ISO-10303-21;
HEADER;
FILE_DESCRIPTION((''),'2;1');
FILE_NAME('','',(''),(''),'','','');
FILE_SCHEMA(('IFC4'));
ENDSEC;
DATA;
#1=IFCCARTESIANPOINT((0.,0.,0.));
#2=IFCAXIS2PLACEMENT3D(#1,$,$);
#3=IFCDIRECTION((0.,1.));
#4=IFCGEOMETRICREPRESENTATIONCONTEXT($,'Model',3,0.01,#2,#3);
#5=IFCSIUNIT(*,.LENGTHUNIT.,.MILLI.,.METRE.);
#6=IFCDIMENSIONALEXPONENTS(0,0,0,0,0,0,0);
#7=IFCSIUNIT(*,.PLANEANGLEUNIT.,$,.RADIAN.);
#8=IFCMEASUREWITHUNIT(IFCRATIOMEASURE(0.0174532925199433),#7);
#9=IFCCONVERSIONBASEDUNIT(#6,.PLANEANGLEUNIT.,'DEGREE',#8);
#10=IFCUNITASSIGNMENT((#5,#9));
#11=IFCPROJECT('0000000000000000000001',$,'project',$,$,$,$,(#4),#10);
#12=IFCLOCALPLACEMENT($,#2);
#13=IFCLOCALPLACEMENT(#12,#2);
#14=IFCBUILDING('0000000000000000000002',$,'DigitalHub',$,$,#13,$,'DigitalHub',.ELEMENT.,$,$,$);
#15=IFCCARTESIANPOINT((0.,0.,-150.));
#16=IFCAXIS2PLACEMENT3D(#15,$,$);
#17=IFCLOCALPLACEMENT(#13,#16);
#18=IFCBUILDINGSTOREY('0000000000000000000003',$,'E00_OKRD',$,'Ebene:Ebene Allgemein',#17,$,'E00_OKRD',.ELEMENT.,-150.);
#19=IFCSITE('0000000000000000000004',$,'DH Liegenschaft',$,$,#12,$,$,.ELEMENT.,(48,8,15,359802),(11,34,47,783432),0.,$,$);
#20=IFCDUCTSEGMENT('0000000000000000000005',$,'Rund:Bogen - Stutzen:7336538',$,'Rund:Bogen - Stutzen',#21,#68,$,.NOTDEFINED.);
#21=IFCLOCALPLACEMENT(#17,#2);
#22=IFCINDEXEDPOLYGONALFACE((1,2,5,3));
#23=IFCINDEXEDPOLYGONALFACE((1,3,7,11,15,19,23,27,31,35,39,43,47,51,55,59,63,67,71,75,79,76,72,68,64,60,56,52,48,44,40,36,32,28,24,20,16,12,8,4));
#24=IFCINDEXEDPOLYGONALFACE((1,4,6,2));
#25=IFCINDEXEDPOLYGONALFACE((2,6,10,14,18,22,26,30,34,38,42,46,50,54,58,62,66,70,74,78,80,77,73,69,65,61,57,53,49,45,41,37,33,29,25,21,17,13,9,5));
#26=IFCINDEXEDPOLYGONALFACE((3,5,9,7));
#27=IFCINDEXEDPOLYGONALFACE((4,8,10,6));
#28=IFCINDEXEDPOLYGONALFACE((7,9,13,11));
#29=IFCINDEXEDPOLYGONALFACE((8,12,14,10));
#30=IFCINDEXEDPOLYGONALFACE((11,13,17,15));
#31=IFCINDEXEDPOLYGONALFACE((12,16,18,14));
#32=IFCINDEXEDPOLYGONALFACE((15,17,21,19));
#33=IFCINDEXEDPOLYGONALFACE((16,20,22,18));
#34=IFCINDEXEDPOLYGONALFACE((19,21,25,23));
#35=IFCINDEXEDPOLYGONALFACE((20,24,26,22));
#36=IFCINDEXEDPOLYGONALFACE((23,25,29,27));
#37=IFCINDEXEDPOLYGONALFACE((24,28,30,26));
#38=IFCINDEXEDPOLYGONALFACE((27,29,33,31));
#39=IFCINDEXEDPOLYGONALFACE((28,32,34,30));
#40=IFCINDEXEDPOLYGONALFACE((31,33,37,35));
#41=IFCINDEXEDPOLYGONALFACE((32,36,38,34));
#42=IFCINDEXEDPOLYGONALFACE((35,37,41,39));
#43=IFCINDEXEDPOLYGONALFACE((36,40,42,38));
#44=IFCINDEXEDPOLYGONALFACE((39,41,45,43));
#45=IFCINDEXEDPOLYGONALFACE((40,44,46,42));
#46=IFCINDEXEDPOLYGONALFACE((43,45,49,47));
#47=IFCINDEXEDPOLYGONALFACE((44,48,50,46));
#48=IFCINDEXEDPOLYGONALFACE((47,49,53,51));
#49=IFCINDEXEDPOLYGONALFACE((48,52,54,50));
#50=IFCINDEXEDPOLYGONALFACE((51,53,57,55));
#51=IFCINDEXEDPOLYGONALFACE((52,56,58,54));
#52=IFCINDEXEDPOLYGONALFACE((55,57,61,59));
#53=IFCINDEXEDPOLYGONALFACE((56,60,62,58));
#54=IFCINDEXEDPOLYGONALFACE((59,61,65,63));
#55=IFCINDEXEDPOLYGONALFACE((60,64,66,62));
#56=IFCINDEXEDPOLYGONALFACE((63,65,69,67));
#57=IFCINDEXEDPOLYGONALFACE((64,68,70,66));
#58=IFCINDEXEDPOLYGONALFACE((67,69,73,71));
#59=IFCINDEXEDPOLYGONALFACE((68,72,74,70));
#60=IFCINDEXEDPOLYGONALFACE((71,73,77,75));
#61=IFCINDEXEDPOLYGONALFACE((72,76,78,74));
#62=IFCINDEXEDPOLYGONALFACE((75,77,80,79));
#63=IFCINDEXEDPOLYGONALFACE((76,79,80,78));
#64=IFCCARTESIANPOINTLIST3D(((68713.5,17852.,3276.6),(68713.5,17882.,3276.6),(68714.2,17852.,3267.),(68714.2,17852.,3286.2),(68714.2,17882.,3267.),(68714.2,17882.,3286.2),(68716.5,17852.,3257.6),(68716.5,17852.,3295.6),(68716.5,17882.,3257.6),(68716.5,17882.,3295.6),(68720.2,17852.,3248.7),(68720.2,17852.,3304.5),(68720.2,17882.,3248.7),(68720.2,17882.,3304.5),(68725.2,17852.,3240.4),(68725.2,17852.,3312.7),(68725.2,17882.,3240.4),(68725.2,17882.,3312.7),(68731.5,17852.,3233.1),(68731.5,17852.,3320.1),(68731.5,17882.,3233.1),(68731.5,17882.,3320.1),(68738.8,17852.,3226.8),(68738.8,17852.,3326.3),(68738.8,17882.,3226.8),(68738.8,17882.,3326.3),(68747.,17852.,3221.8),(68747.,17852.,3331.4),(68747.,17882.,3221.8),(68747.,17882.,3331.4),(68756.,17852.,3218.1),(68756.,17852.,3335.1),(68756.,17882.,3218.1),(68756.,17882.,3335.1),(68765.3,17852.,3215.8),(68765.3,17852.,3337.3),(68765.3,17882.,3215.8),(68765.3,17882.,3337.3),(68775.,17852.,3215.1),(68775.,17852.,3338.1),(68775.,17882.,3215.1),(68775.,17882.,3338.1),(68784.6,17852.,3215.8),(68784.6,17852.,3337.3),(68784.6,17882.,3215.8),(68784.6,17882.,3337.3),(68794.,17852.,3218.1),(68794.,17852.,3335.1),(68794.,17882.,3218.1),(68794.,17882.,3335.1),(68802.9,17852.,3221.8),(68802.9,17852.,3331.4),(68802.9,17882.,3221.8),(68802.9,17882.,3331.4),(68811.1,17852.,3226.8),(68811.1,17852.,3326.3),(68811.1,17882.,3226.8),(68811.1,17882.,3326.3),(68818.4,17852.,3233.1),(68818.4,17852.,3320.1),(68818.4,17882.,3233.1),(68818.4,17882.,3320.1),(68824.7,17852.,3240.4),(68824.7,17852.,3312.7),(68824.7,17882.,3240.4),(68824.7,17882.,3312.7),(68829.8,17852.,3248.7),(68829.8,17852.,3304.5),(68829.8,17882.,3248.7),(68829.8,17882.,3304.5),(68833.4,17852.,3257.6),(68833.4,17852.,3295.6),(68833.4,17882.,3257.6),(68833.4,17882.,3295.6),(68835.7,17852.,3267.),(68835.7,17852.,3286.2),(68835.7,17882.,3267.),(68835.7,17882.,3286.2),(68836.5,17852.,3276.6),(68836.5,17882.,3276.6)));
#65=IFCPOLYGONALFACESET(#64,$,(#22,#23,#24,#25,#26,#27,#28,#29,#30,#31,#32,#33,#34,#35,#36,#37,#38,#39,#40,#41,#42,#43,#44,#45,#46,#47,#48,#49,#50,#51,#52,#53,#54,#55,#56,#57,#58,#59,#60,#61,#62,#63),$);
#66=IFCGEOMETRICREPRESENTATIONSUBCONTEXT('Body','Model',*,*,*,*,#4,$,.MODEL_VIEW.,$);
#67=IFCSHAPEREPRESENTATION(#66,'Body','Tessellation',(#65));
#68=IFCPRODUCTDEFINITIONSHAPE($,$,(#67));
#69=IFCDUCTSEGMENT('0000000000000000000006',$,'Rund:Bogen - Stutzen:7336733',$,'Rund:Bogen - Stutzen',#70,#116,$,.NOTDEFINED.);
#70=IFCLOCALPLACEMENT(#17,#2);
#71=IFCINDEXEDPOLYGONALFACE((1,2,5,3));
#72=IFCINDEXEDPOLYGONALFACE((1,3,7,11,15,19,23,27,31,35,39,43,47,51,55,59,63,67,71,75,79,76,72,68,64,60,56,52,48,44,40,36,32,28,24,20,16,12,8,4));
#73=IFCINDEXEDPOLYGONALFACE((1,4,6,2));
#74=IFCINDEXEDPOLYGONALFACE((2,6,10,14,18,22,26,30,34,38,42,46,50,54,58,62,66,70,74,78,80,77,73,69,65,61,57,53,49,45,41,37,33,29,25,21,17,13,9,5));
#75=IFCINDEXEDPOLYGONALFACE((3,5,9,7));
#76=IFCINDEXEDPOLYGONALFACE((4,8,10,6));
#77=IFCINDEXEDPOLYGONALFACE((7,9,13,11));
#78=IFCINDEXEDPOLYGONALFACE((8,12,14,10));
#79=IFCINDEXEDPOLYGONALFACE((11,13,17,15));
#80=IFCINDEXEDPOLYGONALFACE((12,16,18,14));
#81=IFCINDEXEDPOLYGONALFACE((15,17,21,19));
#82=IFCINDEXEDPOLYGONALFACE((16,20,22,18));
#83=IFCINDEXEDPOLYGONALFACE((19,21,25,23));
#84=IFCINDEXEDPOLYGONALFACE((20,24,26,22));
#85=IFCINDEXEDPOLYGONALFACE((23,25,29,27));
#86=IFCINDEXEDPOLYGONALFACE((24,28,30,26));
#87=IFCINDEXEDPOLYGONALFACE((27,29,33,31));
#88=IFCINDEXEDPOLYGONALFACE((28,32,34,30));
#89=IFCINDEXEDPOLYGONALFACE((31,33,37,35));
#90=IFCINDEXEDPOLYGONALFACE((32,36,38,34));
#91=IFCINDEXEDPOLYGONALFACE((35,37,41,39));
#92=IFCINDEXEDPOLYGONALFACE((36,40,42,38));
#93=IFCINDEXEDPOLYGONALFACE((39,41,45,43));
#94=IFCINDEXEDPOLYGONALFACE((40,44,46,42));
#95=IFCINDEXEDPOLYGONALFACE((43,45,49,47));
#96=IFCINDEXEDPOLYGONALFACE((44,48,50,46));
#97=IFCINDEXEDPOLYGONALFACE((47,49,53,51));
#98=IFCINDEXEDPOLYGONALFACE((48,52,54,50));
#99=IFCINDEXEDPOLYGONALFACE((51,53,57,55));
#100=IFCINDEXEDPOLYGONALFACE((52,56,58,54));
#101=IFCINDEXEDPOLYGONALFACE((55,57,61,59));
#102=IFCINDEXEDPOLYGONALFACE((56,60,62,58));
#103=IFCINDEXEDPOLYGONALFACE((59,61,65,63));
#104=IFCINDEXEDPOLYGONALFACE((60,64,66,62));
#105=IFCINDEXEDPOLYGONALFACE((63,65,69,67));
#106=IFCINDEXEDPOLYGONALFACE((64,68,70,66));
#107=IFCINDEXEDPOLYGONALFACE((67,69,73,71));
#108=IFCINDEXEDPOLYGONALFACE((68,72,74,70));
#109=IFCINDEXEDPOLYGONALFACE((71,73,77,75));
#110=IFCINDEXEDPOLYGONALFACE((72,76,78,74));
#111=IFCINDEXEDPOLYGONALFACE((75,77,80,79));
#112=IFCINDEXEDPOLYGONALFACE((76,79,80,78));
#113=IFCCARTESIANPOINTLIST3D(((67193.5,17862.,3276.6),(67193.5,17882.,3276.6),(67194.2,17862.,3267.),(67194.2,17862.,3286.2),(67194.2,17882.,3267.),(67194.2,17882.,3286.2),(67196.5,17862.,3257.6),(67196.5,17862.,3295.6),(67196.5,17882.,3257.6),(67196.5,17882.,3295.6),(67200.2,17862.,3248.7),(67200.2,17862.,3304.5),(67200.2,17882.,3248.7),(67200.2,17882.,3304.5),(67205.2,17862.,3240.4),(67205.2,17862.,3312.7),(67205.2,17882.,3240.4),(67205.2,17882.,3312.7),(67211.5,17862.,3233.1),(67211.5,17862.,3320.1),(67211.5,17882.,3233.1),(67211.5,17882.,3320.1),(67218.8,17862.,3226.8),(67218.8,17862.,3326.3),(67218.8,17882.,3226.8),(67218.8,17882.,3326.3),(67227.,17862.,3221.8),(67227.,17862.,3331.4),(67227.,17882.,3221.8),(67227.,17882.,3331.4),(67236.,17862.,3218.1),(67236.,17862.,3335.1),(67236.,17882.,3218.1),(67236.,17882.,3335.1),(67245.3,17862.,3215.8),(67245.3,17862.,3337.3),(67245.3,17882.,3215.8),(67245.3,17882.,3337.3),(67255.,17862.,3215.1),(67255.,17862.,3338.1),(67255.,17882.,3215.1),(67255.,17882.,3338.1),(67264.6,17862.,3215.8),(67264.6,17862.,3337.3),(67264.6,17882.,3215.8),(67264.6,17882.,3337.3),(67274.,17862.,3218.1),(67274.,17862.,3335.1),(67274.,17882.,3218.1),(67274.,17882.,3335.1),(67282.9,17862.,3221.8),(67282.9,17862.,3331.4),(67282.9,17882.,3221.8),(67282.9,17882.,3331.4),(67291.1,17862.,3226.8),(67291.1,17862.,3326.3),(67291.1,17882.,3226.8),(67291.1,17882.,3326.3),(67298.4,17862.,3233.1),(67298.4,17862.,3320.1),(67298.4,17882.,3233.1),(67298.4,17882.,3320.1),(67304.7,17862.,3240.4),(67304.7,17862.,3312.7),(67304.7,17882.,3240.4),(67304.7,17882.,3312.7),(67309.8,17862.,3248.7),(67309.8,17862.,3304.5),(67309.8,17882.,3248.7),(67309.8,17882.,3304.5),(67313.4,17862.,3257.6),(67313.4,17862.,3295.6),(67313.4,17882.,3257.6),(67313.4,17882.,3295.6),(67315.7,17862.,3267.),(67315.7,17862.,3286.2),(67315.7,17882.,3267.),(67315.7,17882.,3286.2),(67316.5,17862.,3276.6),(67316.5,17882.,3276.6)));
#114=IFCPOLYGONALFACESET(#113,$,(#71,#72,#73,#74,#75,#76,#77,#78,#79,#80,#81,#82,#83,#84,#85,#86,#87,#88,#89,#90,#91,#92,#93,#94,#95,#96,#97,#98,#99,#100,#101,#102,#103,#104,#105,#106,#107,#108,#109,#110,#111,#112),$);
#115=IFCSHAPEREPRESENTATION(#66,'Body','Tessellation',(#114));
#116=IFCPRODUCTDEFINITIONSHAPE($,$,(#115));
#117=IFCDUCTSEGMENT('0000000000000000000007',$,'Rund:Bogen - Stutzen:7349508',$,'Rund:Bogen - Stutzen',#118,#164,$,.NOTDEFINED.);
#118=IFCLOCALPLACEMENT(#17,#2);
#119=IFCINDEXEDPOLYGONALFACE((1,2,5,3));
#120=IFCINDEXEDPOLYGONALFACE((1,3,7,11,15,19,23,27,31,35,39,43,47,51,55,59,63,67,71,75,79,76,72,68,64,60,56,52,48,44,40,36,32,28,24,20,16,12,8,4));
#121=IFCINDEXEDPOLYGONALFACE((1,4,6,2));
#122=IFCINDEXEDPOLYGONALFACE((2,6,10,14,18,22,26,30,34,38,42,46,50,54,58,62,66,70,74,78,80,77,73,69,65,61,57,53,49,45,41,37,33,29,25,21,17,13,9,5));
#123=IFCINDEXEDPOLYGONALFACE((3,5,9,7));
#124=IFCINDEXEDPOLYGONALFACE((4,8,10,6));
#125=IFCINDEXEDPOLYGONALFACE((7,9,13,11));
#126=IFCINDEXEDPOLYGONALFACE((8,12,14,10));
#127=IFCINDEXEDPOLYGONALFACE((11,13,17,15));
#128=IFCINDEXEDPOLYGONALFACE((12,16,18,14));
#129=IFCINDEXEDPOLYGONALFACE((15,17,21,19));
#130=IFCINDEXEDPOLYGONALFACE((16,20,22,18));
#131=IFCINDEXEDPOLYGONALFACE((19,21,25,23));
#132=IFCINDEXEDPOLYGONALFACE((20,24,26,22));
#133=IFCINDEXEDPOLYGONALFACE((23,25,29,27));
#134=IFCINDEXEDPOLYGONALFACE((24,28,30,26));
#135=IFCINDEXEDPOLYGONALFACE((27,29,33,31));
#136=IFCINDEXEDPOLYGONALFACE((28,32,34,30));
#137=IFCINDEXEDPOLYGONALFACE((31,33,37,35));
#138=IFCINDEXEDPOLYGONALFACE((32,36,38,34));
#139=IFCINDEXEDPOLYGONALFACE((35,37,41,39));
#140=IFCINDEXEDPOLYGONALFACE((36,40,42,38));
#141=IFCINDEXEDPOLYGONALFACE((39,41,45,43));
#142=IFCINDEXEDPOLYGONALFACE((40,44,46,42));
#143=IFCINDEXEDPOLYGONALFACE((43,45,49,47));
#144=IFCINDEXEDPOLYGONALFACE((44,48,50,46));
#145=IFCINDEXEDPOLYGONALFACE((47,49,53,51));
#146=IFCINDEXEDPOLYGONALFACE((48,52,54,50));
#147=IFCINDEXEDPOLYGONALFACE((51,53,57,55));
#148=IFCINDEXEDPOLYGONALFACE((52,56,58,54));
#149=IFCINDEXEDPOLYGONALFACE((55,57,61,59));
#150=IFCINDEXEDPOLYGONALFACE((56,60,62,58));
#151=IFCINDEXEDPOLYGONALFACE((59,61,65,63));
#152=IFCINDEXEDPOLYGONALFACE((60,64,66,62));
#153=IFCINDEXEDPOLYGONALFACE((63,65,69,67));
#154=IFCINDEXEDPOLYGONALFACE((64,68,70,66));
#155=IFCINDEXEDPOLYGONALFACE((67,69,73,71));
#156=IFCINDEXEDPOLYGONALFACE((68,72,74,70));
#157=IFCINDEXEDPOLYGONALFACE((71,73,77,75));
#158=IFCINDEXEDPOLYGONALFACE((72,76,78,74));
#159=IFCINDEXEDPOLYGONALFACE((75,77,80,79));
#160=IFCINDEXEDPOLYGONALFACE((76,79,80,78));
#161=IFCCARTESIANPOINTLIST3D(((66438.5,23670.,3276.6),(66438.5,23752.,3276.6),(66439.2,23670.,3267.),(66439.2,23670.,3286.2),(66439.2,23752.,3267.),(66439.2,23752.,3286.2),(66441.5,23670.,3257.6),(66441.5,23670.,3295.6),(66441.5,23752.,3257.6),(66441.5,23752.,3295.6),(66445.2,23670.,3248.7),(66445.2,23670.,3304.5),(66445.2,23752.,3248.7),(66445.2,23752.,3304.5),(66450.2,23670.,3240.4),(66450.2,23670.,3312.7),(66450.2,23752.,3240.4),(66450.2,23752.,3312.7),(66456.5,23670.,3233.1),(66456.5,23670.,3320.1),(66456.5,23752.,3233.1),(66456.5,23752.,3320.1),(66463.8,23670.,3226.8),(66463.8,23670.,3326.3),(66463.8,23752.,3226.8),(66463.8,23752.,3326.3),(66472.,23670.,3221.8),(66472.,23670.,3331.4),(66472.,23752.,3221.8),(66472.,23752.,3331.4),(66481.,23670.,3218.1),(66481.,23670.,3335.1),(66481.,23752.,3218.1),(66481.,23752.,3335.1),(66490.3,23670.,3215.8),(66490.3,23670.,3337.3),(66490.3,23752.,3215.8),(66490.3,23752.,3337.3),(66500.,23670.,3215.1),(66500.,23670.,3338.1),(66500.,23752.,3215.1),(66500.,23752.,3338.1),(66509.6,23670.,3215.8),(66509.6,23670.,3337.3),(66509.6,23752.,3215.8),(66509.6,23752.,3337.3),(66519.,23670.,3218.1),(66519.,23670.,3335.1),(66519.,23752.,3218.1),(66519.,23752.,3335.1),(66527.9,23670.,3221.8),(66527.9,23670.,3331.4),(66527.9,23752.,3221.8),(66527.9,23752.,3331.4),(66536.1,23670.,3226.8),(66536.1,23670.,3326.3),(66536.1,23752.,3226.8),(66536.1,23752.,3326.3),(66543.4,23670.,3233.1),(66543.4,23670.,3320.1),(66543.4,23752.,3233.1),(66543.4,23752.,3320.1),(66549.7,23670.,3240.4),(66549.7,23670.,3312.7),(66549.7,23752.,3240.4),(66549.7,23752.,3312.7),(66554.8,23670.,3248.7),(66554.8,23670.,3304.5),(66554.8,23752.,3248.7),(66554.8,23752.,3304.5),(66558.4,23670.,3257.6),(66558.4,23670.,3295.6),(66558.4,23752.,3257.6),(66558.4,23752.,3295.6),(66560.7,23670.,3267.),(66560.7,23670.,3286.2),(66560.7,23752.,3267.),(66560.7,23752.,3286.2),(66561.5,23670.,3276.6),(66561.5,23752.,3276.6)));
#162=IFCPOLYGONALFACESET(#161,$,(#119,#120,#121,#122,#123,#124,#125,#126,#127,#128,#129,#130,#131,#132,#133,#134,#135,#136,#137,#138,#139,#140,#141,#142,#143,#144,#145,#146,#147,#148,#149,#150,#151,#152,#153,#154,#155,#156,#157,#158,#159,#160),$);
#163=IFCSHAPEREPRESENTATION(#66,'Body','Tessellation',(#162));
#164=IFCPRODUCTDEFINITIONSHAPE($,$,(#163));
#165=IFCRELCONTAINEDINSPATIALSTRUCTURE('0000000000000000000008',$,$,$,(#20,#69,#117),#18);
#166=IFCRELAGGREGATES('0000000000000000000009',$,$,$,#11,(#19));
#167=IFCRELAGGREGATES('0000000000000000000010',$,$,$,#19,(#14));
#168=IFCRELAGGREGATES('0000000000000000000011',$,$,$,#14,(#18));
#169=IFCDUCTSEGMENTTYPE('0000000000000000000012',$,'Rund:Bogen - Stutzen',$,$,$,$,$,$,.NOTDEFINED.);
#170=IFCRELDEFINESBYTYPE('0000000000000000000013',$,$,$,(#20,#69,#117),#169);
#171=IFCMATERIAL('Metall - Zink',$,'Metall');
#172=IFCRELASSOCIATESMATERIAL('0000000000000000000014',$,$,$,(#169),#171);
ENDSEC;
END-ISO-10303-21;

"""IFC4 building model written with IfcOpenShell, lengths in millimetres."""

from ifc_helpers import new_model, entity, si_unit, converted_unit, direction, frame, origin, place, context, subcontext, project, spatial, indexed_curve, outline, extrude, material, type_object, element, save


model = new_model("IFC4")

# Units and contexts
model_context = context("Model", 3, precision=0.01, world=origin(), true_north=direction((0.0, 1.0)))
body_context = subcontext(model_context, "Body", "Model", "MODEL_VIEW")
ifc_project = project(units=[si_unit("LENGTHUNIT", "METRE", prefix="MILLI"), converted_unit("PLANEANGLEUNIT", "DEGREE", entity("IfcRatioMeasure", 0.0174532925199433), si_unit("PLANEANGLEUNIT", "RADIAN"), dimensions=[0, 0, 0, 0, 0, 0, 0])], contexts=[model_context])

# Site, building, storey
site_placement = place(None, origin())
site = spatial("IfcSite", under=ifc_project, at=site_placement, Name="DH Liegenschaft", CompositionType="ELEMENT", RefLatitude=(48, 8, 15, 359802), RefLongitude=(11, 34, 47, 783432), RefElevation=0.0)
building_placement = place(site_placement, origin())
building = spatial("IfcBuilding", under=site, at=building_placement, Name="DigitalHub", LongName="DigitalHub", CompositionType="ELEMENT")
storey_placement = place(building_placement, frame((0.0, 0.0, -150.0)))
storey = spatial("IfcBuildingStorey", under=building, at=storey_placement, Name="E00_OKRD", ObjectType="Ebene:Ebene Allgemein", LongName="E00_OKRD", CompositionType="ELEMENT", Elevation=-150.0)

# Shared definitions
ifc_material_1 = material(Name="Metall - Zink", Category="Metall")

# Duct segments
duct_segment_type_1 = type_object("IfcDuctSegmentType", Name="Rund:Bogen - Stutzen", PredefinedType="NOTDEFINED", material=ifc_material_1)
duct_segment_1_placement = place(storey_placement, frame((68711.9, 17852.0, 3213.5)))
element("IfcDuctSegment", 1, at=duct_segment_1_placement, inside=storey, type_object=duct_segment_type_1, Name="Rund:Bogen - Stutzen:7336538", ObjectType="Rund:Bogen - Stutzen", PredefinedType="NOTDEFINED", context=body_context, shape_type="SweptSolid", body=[
    extrude(outline(indexed_curve([(61.5, 0.0), (60.7, 9.6), (58.5, 19.0), (54.8, 27.9), (49.8, 36.1), (43.5, 43.5), (36.1, 49.8), (27.9, 54.8), (19.0, 58.5), (9.6, 60.7), (0.0, 61.5), (-9.6, 60.7), (-19.0, 58.5), (-27.9, 54.8), (-36.1, 49.8), (-43.5, 43.5), (-49.8, 36.1), (-54.8, 27.9), (-58.5, 19.0), (-60.7, 9.6), (-61.5, 0.0), (-60.7, -9.6), (-58.5, -19.0), (-54.8, -27.9), (-49.8, -36.1), (-43.5, -43.5), (-36.1, -49.8), (-27.9, -54.8), (-19.0, -58.5), (-9.6, -60.7), (0.0, -61.5), (9.6, -60.7), (19.0, -58.5), (27.9, -54.8), (36.1, -49.8), (43.5, -43.5), (49.8, -36.1), (54.8, -27.9), (58.5, -19.0), (60.7, -9.6), (61.5, 0.0)], self_intersect=False)), frame((63.1, 0.0, 63.1), z_axis=(0.0, 1.0, 0.0), x_axis=(1.0, 0.0, 0.0)), (0.0, 0.0, 1.0), 30.0),
])
duct_segment_2_placement = place(storey_placement, frame((67191.9, 17862.0, 3213.5)))
element("IfcDuctSegment", 2, at=duct_segment_2_placement, inside=storey, type_object=duct_segment_type_1, Name="Rund:Bogen - Stutzen:7336733", ObjectType="Rund:Bogen - Stutzen", PredefinedType="NOTDEFINED", context=body_context, shape_type="SweptSolid", body=[
    extrude(outline(indexed_curve([(61.5, 0.0), (60.7, 9.6), (58.5, 19.0), (54.8, 27.9), (49.8, 36.1), (43.5, 43.5), (36.1, 49.8), (27.9, 54.8), (19.0, 58.5), (9.6, 60.7), (0.0, 61.5), (-9.6, 60.7), (-19.0, 58.5), (-27.9, 54.8), (-36.1, 49.8), (-43.5, 43.5), (-49.8, 36.1), (-54.8, 27.9), (-58.5, 19.0), (-60.7, 9.6), (-61.5, 0.0), (-60.7, -9.6), (-58.5, -19.0), (-54.8, -27.9), (-49.8, -36.1), (-43.5, -43.5), (-36.1, -49.8), (-27.9, -54.8), (-19.0, -58.5), (-9.6, -60.7), (0.0, -61.5), (9.6, -60.7), (19.0, -58.5), (27.9, -54.8), (36.1, -49.8), (43.5, -43.5), (49.8, -36.1), (54.8, -27.9), (58.5, -19.0), (60.7, -9.6), (61.5, 0.0)], self_intersect=False)), frame((63.1, 0.0, 63.1), z_axis=(0.0, 1.0, 0.0), x_axis=(1.0, 0.0, 0.0)), (0.0, 0.0, 1.0), 20.0),
])
duct_segment_3_placement = place(storey_placement, frame((66436.9, 23670.0, 3213.5)))
element("IfcDuctSegment", 3, at=duct_segment_3_placement, inside=storey, type_object=duct_segment_type_1, Name="Rund:Bogen - Stutzen:7349508", ObjectType="Rund:Bogen - Stutzen", PredefinedType="NOTDEFINED", context=body_context, shape_type="SweptSolid", body=[
    extrude(outline(indexed_curve([(61.5, 0.0), (60.7, 9.6), (58.5, 19.0), (54.8, 27.9), (49.8, 36.1), (43.5, 43.5), (36.1, 49.8), (27.9, 54.8), (19.0, 58.5), (9.6, 60.7), (0.0, 61.5), (-9.6, 60.7), (-19.0, 58.5), (-27.9, 54.8), (-36.1, 49.8), (-43.5, 43.5), (-49.8, 36.1), (-54.8, 27.9), (-58.5, 19.0), (-60.7, 9.6), (-61.5, 0.0), (-60.7, -9.6), (-58.5, -19.0), (-54.8, -27.9), (-49.8, -36.1), (-43.5, -43.5), (-36.1, -49.8), (-27.9, -54.8), (-19.0, -58.5), (-9.6, -60.7), (0.0, -61.5), (9.6, -60.7), (19.0, -58.5), (27.9, -54.8), (36.1, -49.8), (43.5, -43.5), (49.8, -36.1), (54.8, -27.9), (58.5, -19.0), (60.7, -9.6), (61.5, 0.0)], self_intersect=False)), frame((63.1, 0.0, 63.1), z_axis=(0.0, 1.0, 0.0), x_axis=(1.0, 0.0, 0.0)), (0.0, 0.0, 1.0), 82.0),
])

save(model, "model.ifc")
